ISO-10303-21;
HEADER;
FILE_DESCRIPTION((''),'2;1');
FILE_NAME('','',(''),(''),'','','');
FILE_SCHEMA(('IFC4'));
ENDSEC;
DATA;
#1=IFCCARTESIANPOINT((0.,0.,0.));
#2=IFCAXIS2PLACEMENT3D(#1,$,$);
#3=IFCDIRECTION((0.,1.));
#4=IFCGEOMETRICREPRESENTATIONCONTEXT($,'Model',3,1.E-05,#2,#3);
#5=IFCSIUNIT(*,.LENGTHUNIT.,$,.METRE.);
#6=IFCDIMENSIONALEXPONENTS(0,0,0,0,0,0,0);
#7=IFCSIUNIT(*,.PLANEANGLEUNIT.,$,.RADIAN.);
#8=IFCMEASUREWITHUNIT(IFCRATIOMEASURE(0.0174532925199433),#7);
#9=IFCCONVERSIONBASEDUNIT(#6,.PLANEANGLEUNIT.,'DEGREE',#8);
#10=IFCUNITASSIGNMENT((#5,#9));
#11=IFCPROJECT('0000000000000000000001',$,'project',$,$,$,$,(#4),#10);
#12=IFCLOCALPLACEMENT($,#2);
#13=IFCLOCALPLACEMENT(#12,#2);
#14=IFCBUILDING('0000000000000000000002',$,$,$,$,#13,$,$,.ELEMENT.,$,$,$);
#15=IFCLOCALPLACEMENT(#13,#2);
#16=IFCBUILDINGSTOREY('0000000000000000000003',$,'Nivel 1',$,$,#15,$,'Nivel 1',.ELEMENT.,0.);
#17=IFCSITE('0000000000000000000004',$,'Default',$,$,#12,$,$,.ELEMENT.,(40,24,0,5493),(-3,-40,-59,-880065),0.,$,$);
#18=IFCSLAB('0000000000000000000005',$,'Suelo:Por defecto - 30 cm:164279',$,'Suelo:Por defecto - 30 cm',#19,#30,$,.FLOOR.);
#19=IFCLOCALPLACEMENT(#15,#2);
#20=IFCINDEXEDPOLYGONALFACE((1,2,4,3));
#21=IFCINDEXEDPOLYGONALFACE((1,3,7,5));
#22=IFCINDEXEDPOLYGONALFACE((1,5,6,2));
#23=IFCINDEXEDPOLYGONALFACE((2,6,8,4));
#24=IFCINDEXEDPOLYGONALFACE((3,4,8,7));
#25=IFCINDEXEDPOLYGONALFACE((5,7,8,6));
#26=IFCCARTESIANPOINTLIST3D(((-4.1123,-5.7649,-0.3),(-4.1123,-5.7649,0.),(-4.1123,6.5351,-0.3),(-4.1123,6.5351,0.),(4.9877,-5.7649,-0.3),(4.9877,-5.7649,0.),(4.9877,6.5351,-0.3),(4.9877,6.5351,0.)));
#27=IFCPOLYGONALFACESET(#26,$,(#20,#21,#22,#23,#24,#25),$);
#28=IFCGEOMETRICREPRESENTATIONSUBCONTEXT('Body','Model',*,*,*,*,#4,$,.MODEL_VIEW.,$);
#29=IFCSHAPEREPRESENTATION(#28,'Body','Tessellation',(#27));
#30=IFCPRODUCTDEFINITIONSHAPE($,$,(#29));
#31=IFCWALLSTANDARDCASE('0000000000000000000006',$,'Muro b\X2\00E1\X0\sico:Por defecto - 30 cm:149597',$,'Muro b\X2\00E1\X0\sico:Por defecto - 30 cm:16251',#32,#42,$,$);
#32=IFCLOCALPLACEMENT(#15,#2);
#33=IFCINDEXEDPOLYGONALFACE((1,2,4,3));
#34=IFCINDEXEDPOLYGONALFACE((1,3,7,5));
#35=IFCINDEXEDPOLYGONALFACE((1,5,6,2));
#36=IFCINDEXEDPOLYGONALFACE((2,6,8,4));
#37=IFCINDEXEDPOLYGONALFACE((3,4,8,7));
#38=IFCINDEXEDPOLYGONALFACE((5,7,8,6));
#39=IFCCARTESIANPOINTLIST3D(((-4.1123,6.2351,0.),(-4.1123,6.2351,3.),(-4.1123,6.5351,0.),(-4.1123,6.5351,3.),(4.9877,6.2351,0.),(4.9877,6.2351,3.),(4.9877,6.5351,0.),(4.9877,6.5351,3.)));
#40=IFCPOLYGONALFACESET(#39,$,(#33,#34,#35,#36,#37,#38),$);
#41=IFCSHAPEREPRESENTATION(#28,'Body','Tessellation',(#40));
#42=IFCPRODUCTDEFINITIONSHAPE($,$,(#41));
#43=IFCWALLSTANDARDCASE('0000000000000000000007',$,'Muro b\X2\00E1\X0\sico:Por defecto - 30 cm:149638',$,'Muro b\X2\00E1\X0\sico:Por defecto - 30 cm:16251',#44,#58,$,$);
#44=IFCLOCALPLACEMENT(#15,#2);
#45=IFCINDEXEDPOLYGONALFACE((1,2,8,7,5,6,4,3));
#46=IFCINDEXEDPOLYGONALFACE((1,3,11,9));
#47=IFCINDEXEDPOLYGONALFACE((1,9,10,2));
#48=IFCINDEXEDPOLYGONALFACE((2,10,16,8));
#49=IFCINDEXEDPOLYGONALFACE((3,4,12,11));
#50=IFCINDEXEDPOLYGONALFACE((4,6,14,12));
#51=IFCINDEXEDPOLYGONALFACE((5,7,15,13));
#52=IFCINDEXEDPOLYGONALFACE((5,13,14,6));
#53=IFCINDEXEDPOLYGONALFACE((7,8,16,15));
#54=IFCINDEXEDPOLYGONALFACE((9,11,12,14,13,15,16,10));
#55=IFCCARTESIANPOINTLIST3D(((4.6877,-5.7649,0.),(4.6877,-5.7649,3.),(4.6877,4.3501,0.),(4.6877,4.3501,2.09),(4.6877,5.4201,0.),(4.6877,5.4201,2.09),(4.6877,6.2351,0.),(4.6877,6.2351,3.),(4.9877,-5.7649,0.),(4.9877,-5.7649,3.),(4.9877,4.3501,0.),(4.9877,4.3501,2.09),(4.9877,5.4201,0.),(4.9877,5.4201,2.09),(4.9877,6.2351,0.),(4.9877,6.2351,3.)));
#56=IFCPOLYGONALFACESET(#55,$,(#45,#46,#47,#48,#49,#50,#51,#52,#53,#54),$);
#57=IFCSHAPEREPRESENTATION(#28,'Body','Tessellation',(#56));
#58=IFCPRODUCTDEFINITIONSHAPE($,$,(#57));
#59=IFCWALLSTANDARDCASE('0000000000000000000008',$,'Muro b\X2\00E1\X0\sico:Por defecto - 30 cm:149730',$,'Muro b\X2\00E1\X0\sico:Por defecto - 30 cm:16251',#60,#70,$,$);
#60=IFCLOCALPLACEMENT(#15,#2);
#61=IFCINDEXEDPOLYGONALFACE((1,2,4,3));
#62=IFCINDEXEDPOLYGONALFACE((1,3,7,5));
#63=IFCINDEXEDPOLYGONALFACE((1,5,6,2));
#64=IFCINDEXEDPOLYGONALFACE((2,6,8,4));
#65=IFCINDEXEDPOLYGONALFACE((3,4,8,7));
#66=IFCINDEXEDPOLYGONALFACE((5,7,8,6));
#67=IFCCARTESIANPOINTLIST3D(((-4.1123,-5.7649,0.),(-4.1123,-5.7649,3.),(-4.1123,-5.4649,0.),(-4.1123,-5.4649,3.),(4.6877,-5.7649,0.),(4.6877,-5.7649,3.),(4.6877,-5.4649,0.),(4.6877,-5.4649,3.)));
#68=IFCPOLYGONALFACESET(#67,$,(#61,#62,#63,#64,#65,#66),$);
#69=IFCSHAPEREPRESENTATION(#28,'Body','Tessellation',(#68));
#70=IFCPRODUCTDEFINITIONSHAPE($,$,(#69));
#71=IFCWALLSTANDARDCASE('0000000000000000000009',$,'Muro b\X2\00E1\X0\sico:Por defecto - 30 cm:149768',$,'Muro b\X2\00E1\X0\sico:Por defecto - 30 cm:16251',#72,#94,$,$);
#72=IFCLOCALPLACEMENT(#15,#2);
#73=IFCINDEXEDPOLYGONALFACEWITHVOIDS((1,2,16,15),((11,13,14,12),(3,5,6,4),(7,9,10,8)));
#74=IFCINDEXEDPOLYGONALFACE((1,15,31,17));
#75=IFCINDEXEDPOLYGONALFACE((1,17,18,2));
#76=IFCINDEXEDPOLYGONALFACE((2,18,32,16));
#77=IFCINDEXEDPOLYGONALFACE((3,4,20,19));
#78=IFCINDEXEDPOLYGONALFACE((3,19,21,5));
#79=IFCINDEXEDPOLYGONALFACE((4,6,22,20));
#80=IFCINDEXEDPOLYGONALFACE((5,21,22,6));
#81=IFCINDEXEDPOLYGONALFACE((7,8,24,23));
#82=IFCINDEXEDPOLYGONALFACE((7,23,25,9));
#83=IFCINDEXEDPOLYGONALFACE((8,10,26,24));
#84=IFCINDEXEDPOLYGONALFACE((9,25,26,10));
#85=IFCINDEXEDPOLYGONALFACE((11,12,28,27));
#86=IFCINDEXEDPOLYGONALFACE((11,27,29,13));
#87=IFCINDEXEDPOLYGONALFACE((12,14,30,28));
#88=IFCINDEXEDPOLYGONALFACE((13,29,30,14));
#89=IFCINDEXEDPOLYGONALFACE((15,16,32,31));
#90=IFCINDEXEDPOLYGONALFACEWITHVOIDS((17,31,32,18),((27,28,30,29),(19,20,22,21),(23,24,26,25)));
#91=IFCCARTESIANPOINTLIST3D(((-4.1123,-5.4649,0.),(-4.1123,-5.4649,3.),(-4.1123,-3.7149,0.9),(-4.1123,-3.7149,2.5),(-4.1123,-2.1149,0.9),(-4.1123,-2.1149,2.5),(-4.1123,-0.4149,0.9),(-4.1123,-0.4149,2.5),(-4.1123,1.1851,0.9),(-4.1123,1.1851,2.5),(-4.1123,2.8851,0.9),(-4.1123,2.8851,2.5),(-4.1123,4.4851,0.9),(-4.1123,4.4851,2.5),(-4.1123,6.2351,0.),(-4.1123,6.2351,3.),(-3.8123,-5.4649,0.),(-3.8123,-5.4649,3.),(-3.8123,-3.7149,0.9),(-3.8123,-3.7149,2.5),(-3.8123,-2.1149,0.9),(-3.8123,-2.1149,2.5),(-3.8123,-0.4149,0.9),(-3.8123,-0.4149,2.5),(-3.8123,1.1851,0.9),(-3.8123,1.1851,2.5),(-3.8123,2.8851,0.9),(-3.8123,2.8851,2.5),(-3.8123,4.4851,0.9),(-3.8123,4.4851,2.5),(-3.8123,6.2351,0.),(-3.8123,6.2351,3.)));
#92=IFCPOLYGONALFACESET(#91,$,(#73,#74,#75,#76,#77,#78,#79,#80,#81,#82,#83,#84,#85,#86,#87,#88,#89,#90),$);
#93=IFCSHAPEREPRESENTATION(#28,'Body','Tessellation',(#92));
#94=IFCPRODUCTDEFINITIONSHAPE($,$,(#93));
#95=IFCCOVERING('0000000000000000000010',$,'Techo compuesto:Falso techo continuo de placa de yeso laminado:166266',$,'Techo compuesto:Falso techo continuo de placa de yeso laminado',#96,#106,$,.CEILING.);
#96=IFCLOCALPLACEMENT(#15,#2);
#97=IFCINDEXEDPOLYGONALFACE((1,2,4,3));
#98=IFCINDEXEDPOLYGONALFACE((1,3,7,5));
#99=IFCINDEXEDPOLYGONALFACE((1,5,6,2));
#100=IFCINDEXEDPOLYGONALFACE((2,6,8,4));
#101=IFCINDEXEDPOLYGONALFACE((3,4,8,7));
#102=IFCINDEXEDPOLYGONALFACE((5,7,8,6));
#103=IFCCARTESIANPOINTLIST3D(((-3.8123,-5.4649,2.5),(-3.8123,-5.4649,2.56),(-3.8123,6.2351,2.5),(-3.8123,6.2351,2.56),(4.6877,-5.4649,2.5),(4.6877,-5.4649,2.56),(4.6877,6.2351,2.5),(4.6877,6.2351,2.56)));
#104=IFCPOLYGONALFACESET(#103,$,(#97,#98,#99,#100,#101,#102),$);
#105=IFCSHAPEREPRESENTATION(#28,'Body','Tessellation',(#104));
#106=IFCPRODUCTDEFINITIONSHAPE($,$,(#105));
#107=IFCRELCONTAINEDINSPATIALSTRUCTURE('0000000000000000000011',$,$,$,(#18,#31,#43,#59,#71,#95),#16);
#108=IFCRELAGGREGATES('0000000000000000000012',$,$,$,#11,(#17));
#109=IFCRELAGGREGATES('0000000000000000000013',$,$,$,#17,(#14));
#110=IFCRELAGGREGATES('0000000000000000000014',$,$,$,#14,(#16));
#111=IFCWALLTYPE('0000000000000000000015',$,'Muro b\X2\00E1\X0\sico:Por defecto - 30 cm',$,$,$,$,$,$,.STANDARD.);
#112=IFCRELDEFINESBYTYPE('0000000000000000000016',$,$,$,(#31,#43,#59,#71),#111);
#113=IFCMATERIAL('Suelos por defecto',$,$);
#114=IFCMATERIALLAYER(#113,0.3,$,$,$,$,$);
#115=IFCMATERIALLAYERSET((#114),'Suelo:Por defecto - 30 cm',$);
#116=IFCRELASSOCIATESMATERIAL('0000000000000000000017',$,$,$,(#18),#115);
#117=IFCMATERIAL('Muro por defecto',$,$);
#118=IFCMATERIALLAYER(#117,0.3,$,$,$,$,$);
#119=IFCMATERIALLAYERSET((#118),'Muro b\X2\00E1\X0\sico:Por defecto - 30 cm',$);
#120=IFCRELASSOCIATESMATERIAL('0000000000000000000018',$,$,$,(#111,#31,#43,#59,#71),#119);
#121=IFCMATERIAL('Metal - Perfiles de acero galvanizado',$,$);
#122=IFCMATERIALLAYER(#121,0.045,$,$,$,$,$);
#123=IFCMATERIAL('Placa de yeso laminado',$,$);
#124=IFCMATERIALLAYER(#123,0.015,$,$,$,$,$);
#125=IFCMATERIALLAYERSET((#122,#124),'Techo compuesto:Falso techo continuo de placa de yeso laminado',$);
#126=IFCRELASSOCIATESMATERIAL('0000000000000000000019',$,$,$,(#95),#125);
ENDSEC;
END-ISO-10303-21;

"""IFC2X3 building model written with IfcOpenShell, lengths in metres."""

from ifc_helpers import new_model, entity, si_unit, converted_unit, direction, frame, frame_2d, origin, place, context, subcontext, project, spatial, rectangle, extrude, material, layer, layer_set, layer_usage, type_object, element, save


model = new_model("IFC2X3")

# Units and contexts
model_context = context("Model", 3, precision=1e-05, world=origin(), true_north=direction((0.0, 1.0)))
body_context = subcontext(model_context, "Body", "Model", "MODEL_VIEW")
ifc_project = project(units=[si_unit("LENGTHUNIT", "METRE"), converted_unit("PLANEANGLEUNIT", "DEGREE", entity("IfcRatioMeasure", 0.0174532925199433), si_unit("PLANEANGLEUNIT", "RADIAN"), dimensions=[0, 0, 0, 0, 0, 0, 0])], contexts=[model_context])

# Site, building, storey
site_placement = place(None, origin())
site = spatial("IfcSite", under=ifc_project, at=site_placement, Name="Default", CompositionType="ELEMENT", RefLatitude=(40, 24, 0, 5493), RefLongitude=(-3, -40, -59, -880065), RefElevation=0.0)
building_placement = place(site_placement, origin())
building = spatial("IfcBuilding", under=site, at=building_placement, CompositionType="ELEMENT")
storey_placement = place(building_placement, origin())
storey = spatial("IfcBuildingStorey", under=building, at=storey_placement, Name="Nivel 1", LongName="Nivel 1", CompositionType="ELEMENT", Elevation=0.0)

# Slab
ifc_material_1 = material(Name="Suelos por defecto")
ifc_layer_1 = layer(ifc_material_1, 0.3)
ifc_layer_set_1 = layer_set([ifc_layer_1], Name="Suelo:Por defecto - 30 cm")
ifc_layer_usage_1 = layer_usage(ifc_layer_set_1, "AXIS3", "POSITIVE", 0.0)
slab_placement = place(storey_placement, origin())
element("IfcSlab", 1, at=slab_placement, inside=storey, material=ifc_layer_usage_1, Name="Suelo:Por defecto - 30 cm:164279", ObjectType="Suelo:Por defecto - 30 cm", PredefinedType="FLOOR", context=body_context, shape_type="SweptSolid", body=[
    extrude(rectangle(XDim=12.3, YDim=9.1, at=frame_2d((0.0, 0.0), x_axis=(1.0, 0.0))), frame((0.4377, 0.3851, 0.0), z_axis=(0.0, 0.0, -1.0), x_axis=(0.0, 1.0, 0.0)), (0.0, 0.0, 1.0), 0.3),
])

# Wall
ifc_material_2 = material(Name="Muro por defecto")
ifc_layer_2 = layer(ifc_material_2, 0.3)
ifc_layer_set_2 = layer_set([ifc_layer_2], Name="Muro básico:Por defecto - 30 cm")
ifc_layer_usage_2 = layer_usage(ifc_layer_set_2, "AXIS2", "NEGATIVE", 0.15)
wall_type = type_object("IfcWallType", Name="Muro básico:Por defecto - 30 cm", PredefinedType="STANDARD", material=ifc_layer_set_2)
wall_1_placement = place(storey_placement, frame((-4.1123, 6.3851, 0.0)))
element("IfcWallStandardCase", 2, at=wall_1_placement, inside=storey, type_object=wall_type, material=ifc_layer_usage_2, Name="Muro básico:Por defecto - 30 cm:149597", ObjectType="Muro básico:Por defecto - 30 cm:16251", context=body_context, shape_type="SweptSolid", body=[
    extrude(rectangle(XDim=9.1, YDim=0.3, at=frame_2d((4.55, 0.0), x_axis=(-1.0, 0.0))), origin(), (0.0, 0.0, 1.0), 3.0),
])

# Wall, opening
ifc_layer_usage_3 = layer_usage(ifc_layer_set_2, "AXIS2", "NEGATIVE", 0.15)
wall_2_placement = place(storey_placement, frame((4.8377, 6.2351, 0.0), z_axis=(0.0, 0.0, 1.0), x_axis=(0.0, -1.0, 0.0)))
wall_2 = element("IfcWallStandardCase", 3, at=wall_2_placement, inside=storey, type_object=wall_type, material=ifc_layer_usage_3, Name="Muro básico:Por defecto - 30 cm:149638", ObjectType="Muro básico:Por defecto - 30 cm:16251", context=body_context, shape_type="SweptSolid", body=[
    extrude(rectangle(XDim=12.0, YDim=0.3, at=frame_2d((6.0, 0.0), x_axis=(-1.0, 0.0))), origin(), (0.0, 0.0, 1.0), 3.0),
])
opening_1_placement = place(wall_2_placement, frame((6.2351, -4.8377, 0.0), z_axis=(0.0, 0.0, 1.0), x_axis=(0.0, 1.0, 0.0)))
element("IfcOpeningElement", 4, at=opening_1_placement, cuts=wall_2, ObjectType="Opening", context=body_context, shape_type="SweptSolid", body=[
    extrude(rectangle(XDim=2.09, YDim=1.07, at=frame_2d((0.0, 0.0), x_axis=(0.0, 1.0))), frame((4.6877, 4.8851, 1.045), z_axis=(1.0, 0.0, 0.0), x_axis=(0.0, -1.0, 0.0)), (0.0, 0.0, 1.0), 0.3),
])

# Wall
ifc_layer_usage_4 = layer_usage(ifc_layer_set_2, "AXIS2", "NEGATIVE", 0.15)
wall_3_placement = place(storey_placement, frame((4.6877, -5.6149, 0.0), z_axis=(0.0, 0.0, 1.0), x_axis=(-1.0, 0.0, 0.0)))
element("IfcWallStandardCase", 5, at=wall_3_placement, inside=storey, type_object=wall_type, material=ifc_layer_usage_4, Name="Muro básico:Por defecto - 30 cm:149730", ObjectType="Muro básico:Por defecto - 30 cm:16251", context=body_context, shape_type="SweptSolid", body=[
    extrude(rectangle(XDim=8.8, YDim=0.3, at=frame_2d((4.4, 0.0), x_axis=(-1.0, 0.0))), origin(), (0.0, 0.0, 1.0), 3.0),
])

# Wall, openings
ifc_layer_usage_5 = layer_usage(ifc_layer_set_2, "AXIS2", "NEGATIVE", 0.15)
wall_4_placement = place(storey_placement, frame((-3.9623, -5.4649, 0.0), z_axis=(0.0, 0.0, 1.0), x_axis=(0.0, 1.0, 0.0)))
wall_4 = element("IfcWallStandardCase", 6, at=wall_4_placement, inside=storey, type_object=wall_type, material=ifc_layer_usage_5, Name="Muro básico:Por defecto - 30 cm:149768", ObjectType="Muro básico:Por defecto - 30 cm:16251", context=body_context, shape_type="SweptSolid", body=[
    extrude(rectangle(XDim=11.7, YDim=0.3, at=frame_2d((5.85, 0.0), x_axis=(-1.0, 0.0))), origin(), (0.0, 0.0, 1.0), 3.0),
])
opening_2_placement = place(wall_4_placement, frame((6.65, 0.15, 0.9)))
element("IfcOpeningElement", 7, at=opening_2_placement, cuts=wall_4, ObjectType="Opening", context=body_context, shape_type="SweptSolid", body=[
    extrude(rectangle(XDim=1.6, YDim=1.6, at=frame_2d((0.8, 0.8), x_axis=(1.0, 0.0))), frame((0.0, 0.0, 0.0), z_axis=(0.0, -1.0, 0.0), x_axis=(0.0, 0.0, 1.0)), (0.0, 0.0, 1.0), 0.3),
])
opening_3_placement = place(wall_4_placement, frame((3.35, 0.15, 0.9)))
element("IfcOpeningElement", 8, at=opening_3_placement, cuts=wall_4, ObjectType="Opening", context=body_context, shape_type="SweptSolid", body=[
    extrude(rectangle(XDim=1.6, YDim=1.6, at=frame_2d((0.8, 0.8), x_axis=(1.0, 0.0))), frame((0.0, 0.0, 0.0), z_axis=(0.0, -1.0, 0.0), x_axis=(0.0, 0.0, 1.0)), (0.0, 0.0, 1.0), 0.3),
])
opening_4_placement = place(wall_4_placement, frame((9.95, 0.15, 0.9)))
element("IfcOpeningElement", 9, at=opening_4_placement, cuts=wall_4, ObjectType="Opening", context=body_context, shape_type="SweptSolid", body=[
    extrude(rectangle(XDim=1.6, YDim=1.6, at=frame_2d((0.8, 0.8), x_axis=(1.0, 0.0))), frame((0.0, 0.0, 0.0), z_axis=(0.0, -1.0, 0.0), x_axis=(0.0, 0.0, 1.0)), (0.0, 0.0, 1.0), 0.3),
])

# Covering
ifc_material_3 = material(Name="Metal - Perfiles de acero galvanizado")
ifc_layer_3 = layer(ifc_material_3, 0.045)
ifc_material_4 = material(Name="Placa de yeso laminado")
ifc_layer_4 = layer(ifc_material_4, 0.015)
ifc_layer_set_3 = layer_set([ifc_layer_3, ifc_layer_4], Name="Techo compuesto:Falso techo continuo de placa de yeso laminado")
ifc_layer_usage_6 = layer_usage(ifc_layer_set_3, "AXIS3", "NEGATIVE", 0.0)
covering_placement = place(storey_placement, origin())
element("IfcCovering", 10, at=covering_placement, inside=storey, material=ifc_layer_usage_6, Name="Techo compuesto:Falso techo continuo de placa de yeso laminado:166266", ObjectType="Techo compuesto:Falso techo continuo de placa de yeso laminado", PredefinedType="CEILING", context=body_context, shape_type="SweptSolid", body=[
    extrude(rectangle(XDim=11.7, YDim=8.5, at=frame_2d((0.0, 0.0), x_axis=(1.0, 0.0))), frame((0.4377, 0.3851, 2.5), z_axis=(0.0, 0.0, 1.0), x_axis=(0.0, -1.0, 0.0)), (0.0, 0.0, 1.0), 0.06),
])

save(model, "model.ifc")
